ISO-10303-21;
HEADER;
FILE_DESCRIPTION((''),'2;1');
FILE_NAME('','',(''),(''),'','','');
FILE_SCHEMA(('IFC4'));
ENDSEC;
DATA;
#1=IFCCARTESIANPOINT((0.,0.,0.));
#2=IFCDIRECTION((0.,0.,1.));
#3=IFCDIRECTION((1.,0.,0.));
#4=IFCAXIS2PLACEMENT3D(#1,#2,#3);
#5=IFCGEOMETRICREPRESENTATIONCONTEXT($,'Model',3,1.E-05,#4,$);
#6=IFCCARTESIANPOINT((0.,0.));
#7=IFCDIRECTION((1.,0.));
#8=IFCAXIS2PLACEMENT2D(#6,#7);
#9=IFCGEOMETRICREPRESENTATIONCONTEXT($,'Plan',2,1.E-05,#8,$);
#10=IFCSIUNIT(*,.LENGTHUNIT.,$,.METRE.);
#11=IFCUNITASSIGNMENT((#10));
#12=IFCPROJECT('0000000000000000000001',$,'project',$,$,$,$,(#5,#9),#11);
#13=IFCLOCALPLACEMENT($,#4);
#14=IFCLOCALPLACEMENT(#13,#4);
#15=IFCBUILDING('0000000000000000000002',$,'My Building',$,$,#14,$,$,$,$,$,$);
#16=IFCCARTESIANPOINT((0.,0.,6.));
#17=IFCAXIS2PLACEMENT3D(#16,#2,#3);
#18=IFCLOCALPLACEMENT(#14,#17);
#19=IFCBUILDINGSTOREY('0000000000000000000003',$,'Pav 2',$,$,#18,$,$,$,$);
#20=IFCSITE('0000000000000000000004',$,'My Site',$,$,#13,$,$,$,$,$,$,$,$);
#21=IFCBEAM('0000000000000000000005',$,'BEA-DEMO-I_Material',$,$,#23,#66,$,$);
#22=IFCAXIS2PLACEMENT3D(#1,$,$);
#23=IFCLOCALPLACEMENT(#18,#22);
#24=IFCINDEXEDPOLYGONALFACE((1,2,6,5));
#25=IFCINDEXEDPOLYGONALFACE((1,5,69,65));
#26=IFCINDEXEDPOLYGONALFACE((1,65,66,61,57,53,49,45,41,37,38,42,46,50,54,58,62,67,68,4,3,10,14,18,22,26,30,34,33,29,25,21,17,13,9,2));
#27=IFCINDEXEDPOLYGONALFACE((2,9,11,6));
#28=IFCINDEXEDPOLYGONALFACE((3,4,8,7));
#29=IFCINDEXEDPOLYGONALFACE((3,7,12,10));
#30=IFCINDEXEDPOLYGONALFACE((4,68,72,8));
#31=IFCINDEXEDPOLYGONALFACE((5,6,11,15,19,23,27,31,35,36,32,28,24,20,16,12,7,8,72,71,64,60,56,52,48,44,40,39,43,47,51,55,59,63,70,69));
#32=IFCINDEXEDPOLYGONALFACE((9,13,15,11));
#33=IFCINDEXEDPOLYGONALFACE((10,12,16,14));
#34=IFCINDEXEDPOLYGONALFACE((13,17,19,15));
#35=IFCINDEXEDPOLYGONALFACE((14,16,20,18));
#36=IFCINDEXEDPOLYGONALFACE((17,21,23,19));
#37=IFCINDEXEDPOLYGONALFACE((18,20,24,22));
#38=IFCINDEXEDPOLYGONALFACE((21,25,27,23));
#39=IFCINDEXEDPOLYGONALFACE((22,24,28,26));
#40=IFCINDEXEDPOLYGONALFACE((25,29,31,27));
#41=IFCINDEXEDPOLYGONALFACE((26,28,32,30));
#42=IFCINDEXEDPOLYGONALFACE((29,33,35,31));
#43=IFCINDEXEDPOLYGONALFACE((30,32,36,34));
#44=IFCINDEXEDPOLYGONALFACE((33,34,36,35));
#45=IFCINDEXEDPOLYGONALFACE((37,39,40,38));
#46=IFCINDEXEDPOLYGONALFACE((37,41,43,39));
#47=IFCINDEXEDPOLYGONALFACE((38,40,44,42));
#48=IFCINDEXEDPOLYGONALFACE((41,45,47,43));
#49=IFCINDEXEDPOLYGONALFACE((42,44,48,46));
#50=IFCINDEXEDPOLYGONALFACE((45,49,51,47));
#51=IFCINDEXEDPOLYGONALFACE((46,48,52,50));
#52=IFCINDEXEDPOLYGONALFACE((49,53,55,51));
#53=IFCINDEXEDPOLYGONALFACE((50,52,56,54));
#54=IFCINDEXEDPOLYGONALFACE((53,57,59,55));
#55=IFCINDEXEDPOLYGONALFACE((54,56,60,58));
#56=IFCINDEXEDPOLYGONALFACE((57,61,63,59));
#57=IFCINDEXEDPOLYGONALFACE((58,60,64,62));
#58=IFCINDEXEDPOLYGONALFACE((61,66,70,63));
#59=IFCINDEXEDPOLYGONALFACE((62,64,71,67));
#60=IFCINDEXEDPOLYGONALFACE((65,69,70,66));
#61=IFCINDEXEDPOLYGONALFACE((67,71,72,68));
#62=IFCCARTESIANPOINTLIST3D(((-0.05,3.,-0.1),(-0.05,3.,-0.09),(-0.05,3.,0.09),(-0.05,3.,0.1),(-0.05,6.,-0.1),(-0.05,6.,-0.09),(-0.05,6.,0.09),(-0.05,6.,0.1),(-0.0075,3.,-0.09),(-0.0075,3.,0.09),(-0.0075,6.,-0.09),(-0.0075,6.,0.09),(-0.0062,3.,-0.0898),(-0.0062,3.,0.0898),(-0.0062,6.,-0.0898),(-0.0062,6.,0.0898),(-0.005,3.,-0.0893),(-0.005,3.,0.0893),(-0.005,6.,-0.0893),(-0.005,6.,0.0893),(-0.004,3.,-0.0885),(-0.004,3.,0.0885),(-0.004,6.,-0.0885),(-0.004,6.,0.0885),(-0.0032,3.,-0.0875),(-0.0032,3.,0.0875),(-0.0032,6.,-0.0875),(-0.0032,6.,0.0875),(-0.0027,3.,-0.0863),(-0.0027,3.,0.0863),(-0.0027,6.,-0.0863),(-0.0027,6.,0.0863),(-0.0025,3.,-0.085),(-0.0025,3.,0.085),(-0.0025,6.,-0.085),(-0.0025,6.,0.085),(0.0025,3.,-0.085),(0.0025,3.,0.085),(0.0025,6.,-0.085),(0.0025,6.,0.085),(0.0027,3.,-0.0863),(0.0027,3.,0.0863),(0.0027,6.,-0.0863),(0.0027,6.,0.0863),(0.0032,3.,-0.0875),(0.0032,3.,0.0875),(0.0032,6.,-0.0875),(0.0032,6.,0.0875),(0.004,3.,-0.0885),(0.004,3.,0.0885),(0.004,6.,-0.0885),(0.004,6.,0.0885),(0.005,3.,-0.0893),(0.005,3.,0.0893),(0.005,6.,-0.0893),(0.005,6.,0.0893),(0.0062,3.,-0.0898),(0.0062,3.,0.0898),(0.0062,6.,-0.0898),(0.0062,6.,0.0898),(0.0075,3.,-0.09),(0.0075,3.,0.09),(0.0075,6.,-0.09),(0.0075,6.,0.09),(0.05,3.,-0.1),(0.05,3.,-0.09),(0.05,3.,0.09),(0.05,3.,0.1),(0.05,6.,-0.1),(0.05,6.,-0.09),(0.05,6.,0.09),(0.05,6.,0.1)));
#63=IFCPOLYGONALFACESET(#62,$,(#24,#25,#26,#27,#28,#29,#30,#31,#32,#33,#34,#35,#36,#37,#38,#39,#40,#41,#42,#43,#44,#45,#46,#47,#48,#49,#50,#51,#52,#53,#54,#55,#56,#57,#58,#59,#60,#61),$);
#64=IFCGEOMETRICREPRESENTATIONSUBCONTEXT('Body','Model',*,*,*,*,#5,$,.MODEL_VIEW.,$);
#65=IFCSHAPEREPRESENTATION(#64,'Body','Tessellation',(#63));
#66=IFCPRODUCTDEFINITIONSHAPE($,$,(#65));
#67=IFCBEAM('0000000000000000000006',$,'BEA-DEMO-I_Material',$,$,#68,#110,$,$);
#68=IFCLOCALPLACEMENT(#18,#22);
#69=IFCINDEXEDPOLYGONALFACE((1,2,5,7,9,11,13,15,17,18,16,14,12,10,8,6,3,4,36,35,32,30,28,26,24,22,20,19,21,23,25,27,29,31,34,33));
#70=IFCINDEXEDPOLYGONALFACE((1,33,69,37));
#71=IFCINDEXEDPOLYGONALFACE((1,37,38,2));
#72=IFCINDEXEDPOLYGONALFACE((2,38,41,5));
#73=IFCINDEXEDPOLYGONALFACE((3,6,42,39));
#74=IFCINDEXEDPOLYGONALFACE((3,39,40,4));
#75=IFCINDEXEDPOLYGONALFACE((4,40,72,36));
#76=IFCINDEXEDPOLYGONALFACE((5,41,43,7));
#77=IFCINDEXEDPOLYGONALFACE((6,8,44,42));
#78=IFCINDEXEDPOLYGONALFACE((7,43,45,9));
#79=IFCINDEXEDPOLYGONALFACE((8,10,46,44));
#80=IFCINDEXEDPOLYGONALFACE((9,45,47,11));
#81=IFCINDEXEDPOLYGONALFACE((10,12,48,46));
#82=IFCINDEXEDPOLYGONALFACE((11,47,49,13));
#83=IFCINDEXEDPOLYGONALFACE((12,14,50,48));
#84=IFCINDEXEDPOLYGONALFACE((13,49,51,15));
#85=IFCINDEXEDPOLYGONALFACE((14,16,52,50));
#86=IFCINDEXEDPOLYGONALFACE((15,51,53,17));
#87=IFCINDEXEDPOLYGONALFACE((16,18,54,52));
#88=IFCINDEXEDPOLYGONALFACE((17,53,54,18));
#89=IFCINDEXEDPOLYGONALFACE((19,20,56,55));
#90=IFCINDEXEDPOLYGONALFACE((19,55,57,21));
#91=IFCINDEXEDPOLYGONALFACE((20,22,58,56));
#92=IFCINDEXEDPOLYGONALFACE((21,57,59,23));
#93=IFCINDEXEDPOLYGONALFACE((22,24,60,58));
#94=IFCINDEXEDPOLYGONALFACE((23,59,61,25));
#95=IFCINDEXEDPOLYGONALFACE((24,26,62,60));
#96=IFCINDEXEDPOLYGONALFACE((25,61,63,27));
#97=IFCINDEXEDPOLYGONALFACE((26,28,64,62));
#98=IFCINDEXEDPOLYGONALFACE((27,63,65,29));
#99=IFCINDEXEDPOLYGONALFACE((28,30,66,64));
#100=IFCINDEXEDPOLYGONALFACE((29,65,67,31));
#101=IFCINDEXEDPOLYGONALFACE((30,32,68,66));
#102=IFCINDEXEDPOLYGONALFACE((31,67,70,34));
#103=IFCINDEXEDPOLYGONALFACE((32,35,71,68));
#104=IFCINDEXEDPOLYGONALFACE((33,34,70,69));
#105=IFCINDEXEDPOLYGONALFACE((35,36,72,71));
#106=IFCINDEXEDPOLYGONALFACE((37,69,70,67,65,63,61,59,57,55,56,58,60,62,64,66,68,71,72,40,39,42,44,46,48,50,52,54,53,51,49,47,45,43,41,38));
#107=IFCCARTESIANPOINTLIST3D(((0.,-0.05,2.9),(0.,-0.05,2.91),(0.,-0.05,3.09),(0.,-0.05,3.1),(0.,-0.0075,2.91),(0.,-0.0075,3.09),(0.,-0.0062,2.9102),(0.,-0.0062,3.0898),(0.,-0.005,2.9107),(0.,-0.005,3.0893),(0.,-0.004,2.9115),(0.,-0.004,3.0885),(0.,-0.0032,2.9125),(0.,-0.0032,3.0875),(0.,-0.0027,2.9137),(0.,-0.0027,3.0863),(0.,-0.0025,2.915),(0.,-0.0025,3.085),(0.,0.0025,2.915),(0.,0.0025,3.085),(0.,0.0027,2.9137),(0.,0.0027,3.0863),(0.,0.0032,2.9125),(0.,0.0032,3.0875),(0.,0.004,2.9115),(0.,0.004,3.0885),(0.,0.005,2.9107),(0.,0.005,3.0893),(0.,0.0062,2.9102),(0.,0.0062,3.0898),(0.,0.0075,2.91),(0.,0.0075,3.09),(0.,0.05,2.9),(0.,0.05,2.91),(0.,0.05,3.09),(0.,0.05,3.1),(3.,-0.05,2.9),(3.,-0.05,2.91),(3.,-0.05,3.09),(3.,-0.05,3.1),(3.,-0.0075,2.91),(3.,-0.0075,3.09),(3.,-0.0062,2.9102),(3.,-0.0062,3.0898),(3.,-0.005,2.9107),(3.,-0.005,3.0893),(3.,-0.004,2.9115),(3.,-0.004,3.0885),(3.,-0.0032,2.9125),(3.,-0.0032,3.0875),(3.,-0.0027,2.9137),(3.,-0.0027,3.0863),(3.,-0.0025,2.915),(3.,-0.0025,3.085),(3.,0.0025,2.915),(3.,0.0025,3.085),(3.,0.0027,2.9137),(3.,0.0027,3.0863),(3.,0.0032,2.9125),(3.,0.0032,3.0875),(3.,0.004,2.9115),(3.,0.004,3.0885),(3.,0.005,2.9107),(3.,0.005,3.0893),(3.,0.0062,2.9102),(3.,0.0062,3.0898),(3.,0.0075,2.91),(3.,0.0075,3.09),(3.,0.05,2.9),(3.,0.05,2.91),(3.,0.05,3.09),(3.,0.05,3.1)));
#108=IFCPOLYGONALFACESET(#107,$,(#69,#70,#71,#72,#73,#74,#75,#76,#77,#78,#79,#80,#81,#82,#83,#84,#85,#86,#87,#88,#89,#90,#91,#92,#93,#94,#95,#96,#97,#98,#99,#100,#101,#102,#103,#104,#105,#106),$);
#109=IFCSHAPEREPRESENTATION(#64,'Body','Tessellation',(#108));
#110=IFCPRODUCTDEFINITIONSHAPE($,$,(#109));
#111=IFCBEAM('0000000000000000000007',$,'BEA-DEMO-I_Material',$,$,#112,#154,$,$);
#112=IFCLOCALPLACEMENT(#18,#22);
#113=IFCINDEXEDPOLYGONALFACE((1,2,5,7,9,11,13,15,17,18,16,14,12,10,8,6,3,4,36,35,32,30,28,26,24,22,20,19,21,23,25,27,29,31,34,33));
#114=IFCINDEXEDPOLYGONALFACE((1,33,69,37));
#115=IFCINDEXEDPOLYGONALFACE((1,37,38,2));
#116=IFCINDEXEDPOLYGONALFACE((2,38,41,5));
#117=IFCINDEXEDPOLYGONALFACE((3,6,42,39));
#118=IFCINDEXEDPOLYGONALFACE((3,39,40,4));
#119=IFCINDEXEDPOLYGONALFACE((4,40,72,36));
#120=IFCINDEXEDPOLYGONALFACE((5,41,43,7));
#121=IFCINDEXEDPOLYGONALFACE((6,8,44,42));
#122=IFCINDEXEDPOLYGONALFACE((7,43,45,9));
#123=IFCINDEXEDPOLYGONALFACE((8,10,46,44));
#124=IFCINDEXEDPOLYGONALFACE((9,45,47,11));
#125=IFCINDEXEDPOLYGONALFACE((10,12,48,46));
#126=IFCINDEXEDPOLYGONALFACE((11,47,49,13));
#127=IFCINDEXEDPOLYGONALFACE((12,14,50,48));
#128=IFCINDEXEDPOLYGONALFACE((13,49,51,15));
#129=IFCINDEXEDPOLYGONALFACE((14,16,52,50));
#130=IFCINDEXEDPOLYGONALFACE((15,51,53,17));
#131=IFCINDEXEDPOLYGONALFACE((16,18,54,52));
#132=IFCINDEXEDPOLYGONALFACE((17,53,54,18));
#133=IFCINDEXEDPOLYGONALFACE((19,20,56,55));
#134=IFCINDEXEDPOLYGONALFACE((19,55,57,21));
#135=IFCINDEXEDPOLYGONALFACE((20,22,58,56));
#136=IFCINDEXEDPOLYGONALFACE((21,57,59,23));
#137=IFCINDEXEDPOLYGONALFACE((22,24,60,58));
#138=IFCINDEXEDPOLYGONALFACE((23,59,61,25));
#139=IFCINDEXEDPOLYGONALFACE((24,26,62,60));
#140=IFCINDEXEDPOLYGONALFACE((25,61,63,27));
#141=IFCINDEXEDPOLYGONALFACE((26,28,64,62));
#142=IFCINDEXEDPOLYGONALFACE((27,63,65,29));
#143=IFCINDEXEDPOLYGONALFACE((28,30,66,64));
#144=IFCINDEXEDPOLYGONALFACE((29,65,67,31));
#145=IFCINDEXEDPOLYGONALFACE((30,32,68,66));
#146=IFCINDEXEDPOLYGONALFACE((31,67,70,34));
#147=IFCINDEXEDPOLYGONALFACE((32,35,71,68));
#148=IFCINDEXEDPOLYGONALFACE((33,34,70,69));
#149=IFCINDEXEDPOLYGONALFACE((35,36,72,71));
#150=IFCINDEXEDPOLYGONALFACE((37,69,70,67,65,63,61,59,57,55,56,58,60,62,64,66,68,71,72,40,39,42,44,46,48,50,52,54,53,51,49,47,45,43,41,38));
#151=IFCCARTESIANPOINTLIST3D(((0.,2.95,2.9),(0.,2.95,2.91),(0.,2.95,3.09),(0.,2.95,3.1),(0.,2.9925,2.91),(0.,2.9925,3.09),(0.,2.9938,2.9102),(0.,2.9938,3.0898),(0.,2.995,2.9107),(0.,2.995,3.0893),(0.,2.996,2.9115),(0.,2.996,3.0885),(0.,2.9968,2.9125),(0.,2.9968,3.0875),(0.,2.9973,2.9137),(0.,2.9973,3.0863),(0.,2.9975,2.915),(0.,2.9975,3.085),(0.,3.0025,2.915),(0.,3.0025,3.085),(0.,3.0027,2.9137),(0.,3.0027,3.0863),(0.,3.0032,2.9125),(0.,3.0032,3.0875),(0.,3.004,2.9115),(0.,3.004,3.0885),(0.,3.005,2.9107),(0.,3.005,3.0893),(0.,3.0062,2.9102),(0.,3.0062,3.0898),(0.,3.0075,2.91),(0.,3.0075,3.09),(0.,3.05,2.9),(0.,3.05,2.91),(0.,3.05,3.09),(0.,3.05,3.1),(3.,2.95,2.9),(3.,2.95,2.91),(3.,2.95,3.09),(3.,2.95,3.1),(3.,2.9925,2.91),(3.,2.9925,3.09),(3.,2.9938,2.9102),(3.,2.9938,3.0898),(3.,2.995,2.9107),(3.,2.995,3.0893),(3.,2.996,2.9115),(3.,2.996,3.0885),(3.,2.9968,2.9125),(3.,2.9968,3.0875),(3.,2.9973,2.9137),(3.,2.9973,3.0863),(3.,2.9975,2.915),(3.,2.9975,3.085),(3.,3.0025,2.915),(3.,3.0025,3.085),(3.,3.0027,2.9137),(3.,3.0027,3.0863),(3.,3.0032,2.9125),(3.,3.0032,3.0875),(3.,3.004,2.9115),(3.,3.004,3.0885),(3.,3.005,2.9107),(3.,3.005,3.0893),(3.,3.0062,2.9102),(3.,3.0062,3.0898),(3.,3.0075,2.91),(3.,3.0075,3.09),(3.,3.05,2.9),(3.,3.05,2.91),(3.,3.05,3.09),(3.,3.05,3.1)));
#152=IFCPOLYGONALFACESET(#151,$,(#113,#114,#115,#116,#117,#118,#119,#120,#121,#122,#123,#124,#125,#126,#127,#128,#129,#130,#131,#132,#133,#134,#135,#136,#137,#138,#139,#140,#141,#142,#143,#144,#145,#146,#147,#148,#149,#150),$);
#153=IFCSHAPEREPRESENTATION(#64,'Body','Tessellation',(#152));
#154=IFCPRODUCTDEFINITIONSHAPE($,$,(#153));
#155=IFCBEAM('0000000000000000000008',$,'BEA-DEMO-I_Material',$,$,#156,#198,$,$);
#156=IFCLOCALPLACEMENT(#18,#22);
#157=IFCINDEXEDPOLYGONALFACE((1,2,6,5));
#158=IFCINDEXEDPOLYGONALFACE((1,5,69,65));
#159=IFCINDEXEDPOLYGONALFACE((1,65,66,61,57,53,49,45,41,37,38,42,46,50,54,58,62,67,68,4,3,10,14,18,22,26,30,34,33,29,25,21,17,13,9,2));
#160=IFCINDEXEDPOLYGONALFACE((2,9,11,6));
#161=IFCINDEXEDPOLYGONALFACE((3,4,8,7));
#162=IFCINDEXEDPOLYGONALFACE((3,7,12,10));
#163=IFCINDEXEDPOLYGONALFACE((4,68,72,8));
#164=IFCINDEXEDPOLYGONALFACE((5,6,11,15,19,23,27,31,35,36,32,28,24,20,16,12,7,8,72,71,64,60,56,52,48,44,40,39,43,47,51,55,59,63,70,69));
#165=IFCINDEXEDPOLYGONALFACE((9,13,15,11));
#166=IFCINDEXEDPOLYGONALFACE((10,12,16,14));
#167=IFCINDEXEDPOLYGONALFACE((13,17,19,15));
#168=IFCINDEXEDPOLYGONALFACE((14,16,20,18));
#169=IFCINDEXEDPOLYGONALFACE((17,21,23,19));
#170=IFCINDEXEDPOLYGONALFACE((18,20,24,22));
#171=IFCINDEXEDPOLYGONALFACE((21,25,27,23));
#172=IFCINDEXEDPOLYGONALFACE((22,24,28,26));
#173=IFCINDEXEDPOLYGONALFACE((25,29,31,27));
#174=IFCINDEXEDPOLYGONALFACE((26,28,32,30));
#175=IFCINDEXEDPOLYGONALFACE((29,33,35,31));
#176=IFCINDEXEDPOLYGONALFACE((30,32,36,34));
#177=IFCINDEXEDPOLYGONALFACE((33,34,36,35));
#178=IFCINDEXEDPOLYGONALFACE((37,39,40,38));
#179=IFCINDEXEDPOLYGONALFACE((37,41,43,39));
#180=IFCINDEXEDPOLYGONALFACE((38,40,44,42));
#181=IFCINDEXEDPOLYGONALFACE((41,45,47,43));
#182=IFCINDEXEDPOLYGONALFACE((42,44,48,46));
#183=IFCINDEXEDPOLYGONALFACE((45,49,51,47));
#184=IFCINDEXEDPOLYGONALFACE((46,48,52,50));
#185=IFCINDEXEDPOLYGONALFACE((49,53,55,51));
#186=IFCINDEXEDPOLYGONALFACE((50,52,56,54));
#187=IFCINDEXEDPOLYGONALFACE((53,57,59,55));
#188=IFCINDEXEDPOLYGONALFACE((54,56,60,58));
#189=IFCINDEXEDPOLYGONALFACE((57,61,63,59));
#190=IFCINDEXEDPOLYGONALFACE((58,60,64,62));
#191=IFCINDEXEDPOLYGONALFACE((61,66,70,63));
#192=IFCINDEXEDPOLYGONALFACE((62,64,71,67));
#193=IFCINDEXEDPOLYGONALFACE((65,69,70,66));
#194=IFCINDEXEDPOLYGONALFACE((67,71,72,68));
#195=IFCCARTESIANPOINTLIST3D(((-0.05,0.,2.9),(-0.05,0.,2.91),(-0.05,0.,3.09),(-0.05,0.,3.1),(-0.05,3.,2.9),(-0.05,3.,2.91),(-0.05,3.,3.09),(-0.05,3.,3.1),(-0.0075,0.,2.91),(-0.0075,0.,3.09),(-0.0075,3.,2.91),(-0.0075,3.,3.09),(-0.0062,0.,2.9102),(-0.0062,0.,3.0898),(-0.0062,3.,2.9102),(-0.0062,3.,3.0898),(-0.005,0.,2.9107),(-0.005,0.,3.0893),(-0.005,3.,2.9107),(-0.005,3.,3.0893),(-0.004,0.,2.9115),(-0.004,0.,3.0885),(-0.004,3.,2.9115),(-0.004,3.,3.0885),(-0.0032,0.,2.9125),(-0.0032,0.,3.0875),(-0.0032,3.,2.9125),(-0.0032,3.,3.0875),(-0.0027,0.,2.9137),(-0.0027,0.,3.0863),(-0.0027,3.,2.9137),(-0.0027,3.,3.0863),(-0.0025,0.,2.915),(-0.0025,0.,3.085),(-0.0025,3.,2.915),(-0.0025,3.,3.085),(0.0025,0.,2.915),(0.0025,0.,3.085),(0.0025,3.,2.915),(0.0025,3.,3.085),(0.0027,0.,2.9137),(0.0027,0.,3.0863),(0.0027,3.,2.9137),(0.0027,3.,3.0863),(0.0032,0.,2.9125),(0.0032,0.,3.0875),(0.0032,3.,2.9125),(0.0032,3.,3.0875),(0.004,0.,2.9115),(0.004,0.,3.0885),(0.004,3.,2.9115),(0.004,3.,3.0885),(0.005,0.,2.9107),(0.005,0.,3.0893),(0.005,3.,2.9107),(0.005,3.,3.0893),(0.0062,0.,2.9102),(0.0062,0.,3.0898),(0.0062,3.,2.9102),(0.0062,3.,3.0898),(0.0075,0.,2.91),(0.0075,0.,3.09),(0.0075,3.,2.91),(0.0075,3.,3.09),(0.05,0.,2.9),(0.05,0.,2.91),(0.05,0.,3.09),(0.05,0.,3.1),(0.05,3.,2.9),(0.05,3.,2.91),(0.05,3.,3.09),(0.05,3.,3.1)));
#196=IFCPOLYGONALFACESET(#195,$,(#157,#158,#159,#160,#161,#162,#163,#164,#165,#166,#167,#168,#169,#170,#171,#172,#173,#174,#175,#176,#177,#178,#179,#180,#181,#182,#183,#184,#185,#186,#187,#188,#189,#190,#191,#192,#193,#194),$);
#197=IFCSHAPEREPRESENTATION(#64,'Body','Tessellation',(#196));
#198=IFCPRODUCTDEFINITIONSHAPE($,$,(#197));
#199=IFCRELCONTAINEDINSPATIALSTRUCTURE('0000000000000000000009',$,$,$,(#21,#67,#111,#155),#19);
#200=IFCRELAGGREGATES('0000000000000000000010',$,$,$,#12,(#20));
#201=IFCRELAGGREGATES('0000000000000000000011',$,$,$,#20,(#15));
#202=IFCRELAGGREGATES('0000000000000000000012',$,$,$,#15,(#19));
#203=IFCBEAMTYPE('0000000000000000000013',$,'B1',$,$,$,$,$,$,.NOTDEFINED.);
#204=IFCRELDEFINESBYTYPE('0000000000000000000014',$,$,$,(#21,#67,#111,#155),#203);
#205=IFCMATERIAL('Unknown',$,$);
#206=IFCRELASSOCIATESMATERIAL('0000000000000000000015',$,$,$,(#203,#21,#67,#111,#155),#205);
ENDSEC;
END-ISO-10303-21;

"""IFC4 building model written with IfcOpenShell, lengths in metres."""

from ifc_helpers import new_model, si_unit, frame, origin, origin_with_axes, origin_2d_with_axis, place, context, subcontext, project, spatial, i_section, extrude, material, material_profile, profile_set, profile_usage, type_object, element, save


model = new_model("IFC4")

# Units and contexts
model_context = context("Model", 3, precision=1e-05, world=origin_with_axes())
plan_context = context("Plan", 2, precision=1e-05, world=origin_2d_with_axis())
body_context = subcontext(model_context, "Body", "Model", "MODEL_VIEW")
ifc_project = project(units=[si_unit("LENGTHUNIT", "METRE")], contexts=[model_context, plan_context])

# Site, building, storey
site_placement = place(None, origin_with_axes())
site = spatial("IfcSite", under=ifc_project, at=site_placement, Name="My Site")
building_placement = place(site_placement, origin_with_axes())
building = spatial("IfcBuilding", under=site, at=building_placement, Name="My Building")
storey_placement = place(building_placement, frame((0.0, 0.0, 6.0), z_axis=(0.0, 0.0, 1.0), x_axis=(1.0, 0.0, 0.0)))
storey = spatial("IfcBuildingStorey", under=building, at=storey_placement, Name="Pav 2")

# Beams
ifc_material = material(Name="Unknown")
ifc_material_profile = material_profile(ifc_material, i_section(OverallWidth=0.1, OverallDepth=0.2, WebThickness=0.005, FlangeThickness=0.01, FilletRadius=0.005))
ifc_profile_set = profile_set([ifc_material_profile])
beam_type = type_object("IfcBeamType", Name="B1", PredefinedType="NOTDEFINED", material=ifc_profile_set)
ifc_profile_usage_1 = profile_usage(ifc_profile_set, cardinal=5)
beam_1_placement = place(storey_placement, frame((0.0, 3.0, 0.0), z_axis=(0.0, 1.0, 0.0), x_axis=(-1.0, 0.0, 0.0)))
element("IfcBeam", 1, at=beam_1_placement, inside=storey, type_object=beam_type, material=ifc_profile_usage_1, Name="BEA-DEMO-I_Material", context=body_context, shape_type="SweptSolid", body=[
    extrude(i_section(OverallWidth=0.1, OverallDepth=0.2, WebThickness=0.005, FlangeThickness=0.01, FilletRadius=0.005), origin(), (0.0, 0.0, 1.0), 3.0),
])
ifc_profile_usage_2 = profile_usage(ifc_profile_set, cardinal=5)
beam_2_placement = place(storey_placement, frame((3.0, 0.0, 3.0), z_axis=(-1.0, 0.0, 0.0), x_axis=(0.0, -1.0, 0.0)))
element("IfcBeam", 2, at=beam_2_placement, inside=storey, type_object=beam_type, material=ifc_profile_usage_2, Name="BEA-DEMO-I_Material", context=body_context, shape_type="SweptSolid", body=[
    extrude(i_section(OverallWidth=0.1, OverallDepth=0.2, WebThickness=0.005, FlangeThickness=0.01, FilletRadius=0.005), origin(), (0.0, 0.0, 1.0), 3.0),
])
ifc_profile_usage_3 = profile_usage(ifc_profile_set, cardinal=5)
beam_3_placement = place(storey_placement, frame((0.0, 3.0, 3.0), z_axis=(1.0, 0.0, 0.0), x_axis=(0.0, 1.0, 0.0)))
element("IfcBeam", 3, at=beam_3_placement, inside=storey, type_object=beam_type, material=ifc_profile_usage_3, Name="BEA-DEMO-I_Material", context=body_context, shape_type="SweptSolid", body=[
    extrude(i_section(OverallWidth=0.1, OverallDepth=0.2, WebThickness=0.005, FlangeThickness=0.01, FilletRadius=0.005), origin(), (0.0, 0.0, 1.0), 3.0),
])
ifc_profile_usage_4 = profile_usage(ifc_profile_set, cardinal=5)
beam_4_placement = place(storey_placement, frame((0.0, 0.0, 3.0), z_axis=(0.0, 1.0, 0.0), x_axis=(-1.0, 0.0, 0.0)))
element("IfcBeam", 4, at=beam_4_placement, inside=storey, type_object=beam_type, material=ifc_profile_usage_4, Name="BEA-DEMO-I_Material", context=body_context, shape_type="SweptSolid", body=[
    extrude(i_section(OverallWidth=0.1, OverallDepth=0.2, WebThickness=0.005, FlangeThickness=0.01, FilletRadius=0.005), origin(), (0.0, 0.0, 1.0), 3.0),
])

save(model, "model.ifc")
